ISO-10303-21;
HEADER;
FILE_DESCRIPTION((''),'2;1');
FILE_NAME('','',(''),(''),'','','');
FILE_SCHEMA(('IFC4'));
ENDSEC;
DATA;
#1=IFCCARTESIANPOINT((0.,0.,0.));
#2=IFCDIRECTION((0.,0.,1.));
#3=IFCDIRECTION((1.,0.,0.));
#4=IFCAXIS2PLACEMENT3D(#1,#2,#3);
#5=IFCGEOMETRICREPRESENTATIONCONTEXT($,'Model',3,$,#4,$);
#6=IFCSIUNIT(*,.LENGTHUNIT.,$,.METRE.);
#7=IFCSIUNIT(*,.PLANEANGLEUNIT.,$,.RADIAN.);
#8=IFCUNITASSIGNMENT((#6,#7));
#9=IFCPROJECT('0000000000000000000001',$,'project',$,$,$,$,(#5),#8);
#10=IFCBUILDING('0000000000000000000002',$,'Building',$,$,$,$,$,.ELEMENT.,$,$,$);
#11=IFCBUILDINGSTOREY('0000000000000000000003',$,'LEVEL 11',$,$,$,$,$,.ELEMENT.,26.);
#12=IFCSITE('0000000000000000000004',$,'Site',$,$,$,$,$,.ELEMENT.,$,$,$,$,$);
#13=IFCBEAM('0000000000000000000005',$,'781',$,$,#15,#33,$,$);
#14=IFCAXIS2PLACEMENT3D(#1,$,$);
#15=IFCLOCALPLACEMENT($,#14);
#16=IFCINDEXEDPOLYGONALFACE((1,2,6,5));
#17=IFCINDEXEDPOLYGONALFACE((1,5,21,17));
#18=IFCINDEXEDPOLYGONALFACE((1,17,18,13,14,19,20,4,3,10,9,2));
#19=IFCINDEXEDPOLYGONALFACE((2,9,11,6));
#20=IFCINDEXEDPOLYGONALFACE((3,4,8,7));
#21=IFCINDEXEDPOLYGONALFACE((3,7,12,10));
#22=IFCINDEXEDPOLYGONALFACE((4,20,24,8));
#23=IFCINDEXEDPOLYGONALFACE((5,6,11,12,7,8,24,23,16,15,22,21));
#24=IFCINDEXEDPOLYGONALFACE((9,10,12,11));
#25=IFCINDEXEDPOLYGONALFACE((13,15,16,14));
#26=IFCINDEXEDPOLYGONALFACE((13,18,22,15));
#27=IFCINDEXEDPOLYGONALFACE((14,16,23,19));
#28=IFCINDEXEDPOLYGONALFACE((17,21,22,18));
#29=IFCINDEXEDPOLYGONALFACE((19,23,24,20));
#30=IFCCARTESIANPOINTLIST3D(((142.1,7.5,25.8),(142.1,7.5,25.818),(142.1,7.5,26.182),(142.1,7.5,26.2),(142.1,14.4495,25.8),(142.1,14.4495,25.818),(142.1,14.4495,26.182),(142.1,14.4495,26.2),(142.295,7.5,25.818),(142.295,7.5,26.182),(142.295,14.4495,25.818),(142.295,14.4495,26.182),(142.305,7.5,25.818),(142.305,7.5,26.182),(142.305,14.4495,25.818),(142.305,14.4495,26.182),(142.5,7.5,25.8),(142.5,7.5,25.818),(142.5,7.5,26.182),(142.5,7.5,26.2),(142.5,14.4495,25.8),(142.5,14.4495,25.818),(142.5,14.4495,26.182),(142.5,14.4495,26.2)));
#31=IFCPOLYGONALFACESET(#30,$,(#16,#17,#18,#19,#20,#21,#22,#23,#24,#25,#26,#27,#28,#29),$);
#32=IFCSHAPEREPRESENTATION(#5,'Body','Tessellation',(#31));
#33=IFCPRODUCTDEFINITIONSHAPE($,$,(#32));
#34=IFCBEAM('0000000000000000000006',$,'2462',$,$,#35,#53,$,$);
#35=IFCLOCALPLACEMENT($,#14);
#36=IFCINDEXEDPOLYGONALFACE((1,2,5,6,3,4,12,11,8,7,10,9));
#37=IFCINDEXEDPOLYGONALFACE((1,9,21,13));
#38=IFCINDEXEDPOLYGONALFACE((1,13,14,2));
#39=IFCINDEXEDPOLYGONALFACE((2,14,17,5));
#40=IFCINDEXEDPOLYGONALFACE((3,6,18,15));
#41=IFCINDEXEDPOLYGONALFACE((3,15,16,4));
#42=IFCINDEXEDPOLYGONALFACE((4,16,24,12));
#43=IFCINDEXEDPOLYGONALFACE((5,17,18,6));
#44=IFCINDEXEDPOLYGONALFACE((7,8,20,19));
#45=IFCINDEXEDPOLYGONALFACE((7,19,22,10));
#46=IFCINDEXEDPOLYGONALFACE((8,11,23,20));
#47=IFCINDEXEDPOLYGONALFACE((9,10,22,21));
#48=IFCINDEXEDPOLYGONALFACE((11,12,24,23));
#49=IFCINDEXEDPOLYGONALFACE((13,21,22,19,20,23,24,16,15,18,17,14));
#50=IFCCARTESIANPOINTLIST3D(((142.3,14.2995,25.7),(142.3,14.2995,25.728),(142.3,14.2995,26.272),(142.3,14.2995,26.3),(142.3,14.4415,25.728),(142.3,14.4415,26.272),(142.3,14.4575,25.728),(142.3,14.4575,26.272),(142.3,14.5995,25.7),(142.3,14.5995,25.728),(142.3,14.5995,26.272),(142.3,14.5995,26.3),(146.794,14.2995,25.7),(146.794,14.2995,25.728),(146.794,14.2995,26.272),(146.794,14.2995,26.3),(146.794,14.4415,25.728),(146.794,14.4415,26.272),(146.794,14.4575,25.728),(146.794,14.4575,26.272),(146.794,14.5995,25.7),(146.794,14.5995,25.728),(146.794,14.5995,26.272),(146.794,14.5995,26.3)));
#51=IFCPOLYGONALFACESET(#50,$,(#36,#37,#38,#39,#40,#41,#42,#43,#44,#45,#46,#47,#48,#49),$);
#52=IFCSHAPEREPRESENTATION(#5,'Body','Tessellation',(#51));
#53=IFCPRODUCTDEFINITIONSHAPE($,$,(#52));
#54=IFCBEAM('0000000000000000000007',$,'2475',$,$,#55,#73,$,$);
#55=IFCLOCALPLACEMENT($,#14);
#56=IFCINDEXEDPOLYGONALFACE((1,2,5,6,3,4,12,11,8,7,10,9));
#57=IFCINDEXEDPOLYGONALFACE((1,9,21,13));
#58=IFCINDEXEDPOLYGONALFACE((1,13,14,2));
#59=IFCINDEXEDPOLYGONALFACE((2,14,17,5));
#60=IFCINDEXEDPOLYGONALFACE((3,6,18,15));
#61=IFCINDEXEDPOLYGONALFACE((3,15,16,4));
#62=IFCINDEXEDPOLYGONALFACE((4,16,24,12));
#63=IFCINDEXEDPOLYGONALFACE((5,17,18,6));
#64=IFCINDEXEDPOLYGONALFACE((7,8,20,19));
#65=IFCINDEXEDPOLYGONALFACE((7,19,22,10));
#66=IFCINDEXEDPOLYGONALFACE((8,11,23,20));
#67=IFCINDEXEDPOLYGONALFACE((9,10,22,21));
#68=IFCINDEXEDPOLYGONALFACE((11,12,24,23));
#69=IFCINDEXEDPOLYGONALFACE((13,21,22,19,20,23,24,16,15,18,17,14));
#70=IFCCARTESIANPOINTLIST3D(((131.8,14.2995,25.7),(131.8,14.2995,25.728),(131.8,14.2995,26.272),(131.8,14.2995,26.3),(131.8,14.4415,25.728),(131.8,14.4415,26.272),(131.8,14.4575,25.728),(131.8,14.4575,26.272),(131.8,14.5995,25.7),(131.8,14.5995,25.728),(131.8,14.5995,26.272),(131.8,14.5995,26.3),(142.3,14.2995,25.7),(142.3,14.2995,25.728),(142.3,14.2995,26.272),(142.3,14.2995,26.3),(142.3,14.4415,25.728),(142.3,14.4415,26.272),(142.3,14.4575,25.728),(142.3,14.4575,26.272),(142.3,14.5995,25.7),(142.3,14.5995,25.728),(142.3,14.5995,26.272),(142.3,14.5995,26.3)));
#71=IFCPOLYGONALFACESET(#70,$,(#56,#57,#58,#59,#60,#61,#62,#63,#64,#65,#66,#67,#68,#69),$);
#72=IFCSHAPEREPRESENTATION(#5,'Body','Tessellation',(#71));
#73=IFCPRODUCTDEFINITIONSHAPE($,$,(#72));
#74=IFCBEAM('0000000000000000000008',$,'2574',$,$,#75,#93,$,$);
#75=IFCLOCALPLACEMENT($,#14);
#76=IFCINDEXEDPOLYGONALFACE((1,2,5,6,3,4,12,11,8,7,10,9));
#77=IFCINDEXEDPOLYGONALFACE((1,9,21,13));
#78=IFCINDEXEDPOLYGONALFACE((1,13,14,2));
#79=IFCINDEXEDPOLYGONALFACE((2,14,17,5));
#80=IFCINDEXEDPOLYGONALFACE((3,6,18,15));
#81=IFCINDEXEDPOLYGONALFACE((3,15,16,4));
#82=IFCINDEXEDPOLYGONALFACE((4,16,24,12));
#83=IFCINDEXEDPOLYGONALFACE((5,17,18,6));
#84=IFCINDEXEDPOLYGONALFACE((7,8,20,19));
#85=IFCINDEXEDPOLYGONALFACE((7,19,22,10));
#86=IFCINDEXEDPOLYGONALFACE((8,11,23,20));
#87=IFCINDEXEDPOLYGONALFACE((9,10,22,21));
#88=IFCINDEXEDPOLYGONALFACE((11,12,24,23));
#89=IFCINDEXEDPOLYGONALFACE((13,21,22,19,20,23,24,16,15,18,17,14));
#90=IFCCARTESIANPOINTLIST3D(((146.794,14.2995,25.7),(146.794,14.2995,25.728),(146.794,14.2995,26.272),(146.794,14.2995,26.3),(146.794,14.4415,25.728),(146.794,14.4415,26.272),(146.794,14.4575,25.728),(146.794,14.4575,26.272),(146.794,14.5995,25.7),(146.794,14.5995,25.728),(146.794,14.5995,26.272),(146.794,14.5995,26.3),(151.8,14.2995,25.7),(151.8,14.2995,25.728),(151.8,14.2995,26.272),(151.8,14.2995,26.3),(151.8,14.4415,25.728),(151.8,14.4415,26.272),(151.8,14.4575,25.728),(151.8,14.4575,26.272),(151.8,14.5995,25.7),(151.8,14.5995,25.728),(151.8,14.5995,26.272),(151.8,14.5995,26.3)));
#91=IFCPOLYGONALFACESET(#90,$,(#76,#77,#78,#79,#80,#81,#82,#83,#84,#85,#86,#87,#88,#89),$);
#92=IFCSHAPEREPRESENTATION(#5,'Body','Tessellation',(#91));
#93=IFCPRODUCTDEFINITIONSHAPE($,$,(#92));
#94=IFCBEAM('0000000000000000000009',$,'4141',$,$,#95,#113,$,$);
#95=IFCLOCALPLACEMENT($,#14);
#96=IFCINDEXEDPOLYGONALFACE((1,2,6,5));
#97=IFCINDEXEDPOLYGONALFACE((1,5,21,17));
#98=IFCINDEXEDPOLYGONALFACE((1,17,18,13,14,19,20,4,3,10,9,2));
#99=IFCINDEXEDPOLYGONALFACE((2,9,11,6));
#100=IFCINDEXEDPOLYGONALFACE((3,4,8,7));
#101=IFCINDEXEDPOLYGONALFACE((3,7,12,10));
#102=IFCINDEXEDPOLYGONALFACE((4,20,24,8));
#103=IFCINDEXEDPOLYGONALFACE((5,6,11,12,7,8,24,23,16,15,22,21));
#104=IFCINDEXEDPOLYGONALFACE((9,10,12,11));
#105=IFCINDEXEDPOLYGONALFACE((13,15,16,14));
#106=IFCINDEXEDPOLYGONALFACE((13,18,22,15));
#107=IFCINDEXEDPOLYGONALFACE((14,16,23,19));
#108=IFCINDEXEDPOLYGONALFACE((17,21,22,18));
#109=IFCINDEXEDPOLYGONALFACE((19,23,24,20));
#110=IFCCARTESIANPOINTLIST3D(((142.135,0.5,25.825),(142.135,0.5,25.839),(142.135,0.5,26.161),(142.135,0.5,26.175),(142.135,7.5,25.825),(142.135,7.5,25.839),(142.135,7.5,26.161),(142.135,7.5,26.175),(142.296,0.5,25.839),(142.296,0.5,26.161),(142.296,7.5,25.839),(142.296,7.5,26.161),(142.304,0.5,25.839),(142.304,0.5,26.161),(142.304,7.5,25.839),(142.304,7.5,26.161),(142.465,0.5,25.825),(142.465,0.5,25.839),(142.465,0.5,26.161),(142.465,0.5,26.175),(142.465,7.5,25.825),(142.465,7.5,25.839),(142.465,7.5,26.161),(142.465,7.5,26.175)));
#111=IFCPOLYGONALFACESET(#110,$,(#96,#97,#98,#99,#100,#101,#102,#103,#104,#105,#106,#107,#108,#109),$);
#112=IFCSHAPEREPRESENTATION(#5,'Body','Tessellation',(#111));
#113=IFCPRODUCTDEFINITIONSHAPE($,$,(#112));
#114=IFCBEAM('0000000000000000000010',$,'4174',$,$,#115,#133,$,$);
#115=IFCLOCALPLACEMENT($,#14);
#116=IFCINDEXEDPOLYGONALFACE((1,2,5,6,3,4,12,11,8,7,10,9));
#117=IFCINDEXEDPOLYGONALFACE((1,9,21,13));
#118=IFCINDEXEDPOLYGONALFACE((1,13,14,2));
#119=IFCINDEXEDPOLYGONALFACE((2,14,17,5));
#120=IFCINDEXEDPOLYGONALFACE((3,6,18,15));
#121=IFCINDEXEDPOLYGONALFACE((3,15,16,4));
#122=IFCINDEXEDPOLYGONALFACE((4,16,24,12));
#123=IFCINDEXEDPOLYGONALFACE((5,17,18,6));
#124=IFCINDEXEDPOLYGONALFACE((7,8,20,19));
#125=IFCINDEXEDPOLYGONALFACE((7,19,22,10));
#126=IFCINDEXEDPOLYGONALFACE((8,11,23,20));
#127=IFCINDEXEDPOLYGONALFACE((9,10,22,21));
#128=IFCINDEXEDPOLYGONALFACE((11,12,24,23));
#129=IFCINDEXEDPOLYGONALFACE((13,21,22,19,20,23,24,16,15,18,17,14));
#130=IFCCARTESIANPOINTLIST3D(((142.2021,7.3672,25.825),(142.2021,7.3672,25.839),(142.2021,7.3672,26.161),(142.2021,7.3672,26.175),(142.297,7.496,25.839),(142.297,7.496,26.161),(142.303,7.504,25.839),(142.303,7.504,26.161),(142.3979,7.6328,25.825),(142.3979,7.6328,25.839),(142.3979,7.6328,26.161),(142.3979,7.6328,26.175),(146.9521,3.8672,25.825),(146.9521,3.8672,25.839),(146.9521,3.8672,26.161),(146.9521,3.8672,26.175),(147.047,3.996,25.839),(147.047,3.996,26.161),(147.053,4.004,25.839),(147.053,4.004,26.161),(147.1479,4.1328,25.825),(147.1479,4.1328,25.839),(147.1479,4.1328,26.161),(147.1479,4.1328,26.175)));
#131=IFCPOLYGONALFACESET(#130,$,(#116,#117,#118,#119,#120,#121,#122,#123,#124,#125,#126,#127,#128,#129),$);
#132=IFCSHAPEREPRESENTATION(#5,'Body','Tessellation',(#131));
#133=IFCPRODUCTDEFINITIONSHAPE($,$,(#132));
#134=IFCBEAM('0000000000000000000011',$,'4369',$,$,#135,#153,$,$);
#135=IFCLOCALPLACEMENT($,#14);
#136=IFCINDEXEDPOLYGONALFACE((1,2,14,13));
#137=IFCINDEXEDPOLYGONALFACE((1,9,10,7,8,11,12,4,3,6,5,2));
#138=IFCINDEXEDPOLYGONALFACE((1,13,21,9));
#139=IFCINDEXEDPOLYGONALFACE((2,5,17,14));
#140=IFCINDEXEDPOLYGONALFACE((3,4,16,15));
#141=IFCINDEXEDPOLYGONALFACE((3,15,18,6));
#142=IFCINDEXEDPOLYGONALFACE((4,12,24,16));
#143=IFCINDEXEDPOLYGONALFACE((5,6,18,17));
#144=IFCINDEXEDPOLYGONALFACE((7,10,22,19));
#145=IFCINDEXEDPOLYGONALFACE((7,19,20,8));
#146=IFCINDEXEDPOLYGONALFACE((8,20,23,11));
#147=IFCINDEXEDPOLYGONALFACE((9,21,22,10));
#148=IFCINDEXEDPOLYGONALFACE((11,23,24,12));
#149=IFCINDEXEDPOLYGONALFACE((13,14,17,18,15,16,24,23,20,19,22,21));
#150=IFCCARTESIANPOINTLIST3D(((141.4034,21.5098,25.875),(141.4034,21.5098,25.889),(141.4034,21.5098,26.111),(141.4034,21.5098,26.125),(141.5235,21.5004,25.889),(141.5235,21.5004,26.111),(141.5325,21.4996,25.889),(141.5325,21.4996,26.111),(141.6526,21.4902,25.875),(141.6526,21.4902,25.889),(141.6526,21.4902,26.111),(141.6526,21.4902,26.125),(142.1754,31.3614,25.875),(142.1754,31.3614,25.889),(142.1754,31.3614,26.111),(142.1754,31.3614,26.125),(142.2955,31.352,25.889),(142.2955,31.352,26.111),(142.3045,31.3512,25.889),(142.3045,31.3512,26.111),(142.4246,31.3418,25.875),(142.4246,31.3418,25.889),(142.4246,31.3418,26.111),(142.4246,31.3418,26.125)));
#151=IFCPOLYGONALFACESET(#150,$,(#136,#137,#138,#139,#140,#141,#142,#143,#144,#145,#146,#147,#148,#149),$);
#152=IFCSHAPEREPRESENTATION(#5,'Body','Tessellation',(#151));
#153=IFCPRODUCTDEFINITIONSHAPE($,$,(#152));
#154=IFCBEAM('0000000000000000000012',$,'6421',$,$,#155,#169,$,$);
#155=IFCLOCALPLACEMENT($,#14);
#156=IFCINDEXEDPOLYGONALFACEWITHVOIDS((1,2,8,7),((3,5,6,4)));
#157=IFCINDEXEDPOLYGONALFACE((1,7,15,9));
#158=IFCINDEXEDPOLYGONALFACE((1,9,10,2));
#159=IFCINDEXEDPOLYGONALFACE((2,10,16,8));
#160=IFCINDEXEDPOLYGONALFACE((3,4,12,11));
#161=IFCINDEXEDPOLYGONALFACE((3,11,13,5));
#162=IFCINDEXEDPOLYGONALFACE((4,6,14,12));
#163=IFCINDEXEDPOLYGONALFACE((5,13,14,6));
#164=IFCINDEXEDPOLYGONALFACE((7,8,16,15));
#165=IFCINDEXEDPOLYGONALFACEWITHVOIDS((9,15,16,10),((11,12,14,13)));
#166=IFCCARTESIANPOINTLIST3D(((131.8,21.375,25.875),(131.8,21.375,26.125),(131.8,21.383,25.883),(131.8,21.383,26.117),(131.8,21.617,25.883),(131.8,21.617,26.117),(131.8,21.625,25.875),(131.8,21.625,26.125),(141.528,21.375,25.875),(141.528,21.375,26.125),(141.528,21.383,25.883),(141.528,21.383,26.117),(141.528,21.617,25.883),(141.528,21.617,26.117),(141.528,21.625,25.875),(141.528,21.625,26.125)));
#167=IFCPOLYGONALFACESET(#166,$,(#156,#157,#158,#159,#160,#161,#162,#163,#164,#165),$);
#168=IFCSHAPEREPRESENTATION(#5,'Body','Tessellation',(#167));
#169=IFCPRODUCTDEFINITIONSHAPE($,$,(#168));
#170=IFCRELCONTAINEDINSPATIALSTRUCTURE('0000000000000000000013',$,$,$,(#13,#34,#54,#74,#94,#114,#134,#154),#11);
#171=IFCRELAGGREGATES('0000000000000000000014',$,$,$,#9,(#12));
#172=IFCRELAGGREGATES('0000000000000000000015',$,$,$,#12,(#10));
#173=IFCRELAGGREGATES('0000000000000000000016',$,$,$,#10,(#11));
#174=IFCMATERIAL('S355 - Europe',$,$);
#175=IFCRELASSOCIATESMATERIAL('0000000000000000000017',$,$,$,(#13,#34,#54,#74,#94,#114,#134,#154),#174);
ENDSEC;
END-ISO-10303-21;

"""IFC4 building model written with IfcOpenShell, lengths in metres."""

from ifc_helpers import new_model, si_unit, frame, origin_with_axes, origin_2d_with_axis, place, context, project, spatial, hollow_rectangle, i_section, extrude, material, material_profile, profile_set, profile_usage, element, save


model = new_model("IFC4")

# Units and contexts
model_context = context("Model", 3, world=origin_with_axes())
ifc_project = project(units=[si_unit("LENGTHUNIT", "METRE"), si_unit("PLANEANGLEUNIT", "RADIAN")], contexts=[model_context])

# Site, building, storey
site = spatial("IfcSite", under=ifc_project, Name="Site", CompositionType="ELEMENT")
building = spatial("IfcBuilding", under=site, Name="Building", CompositionType="ELEMENT")
storey = spatial("IfcBuildingStorey", under=building, Name="LEVEL 11", CompositionType="ELEMENT", Elevation=26.0)

# Shared definitions
ifc_material = material(Name="S355 - Europe")

# Beams
ifc_material_profile_1 = material_profile(ifc_material, i_section(OverallWidth=0.4, OverallDepth=0.4, WebThickness=0.01, FlangeThickness=0.018, at=origin_2d_with_axis()))
ifc_profile_set_1 = profile_set([ifc_material_profile_1])
ifc_profile_usage_1 = profile_usage(ifc_profile_set_1, cardinal=10)
beam_1_placement = place(None, frame((142.3, 14.4495, 26.0), z_axis=(0.0, -1.0, 0.0), x_axis=(1.0, 0.0, 0.0)))
element("IfcBeam", 1, at=beam_1_placement, inside=storey, material=ifc_profile_usage_1, Name="781", context=model_context, shape_type="SweptSolid", body=[
    extrude(i_section(OverallWidth=0.4, OverallDepth=0.4, WebThickness=0.01, FlangeThickness=0.018, at=origin_2d_with_axis()), origin_with_axes(), (0.0, 0.0, 1.0), 6.9495),
])
ifc_material_profile_2 = material_profile(ifc_material, i_section(OverallWidth=0.3, OverallDepth=0.6, WebThickness=0.016, FlangeThickness=0.028, at=origin_2d_with_axis()))
ifc_profile_set_2 = profile_set([ifc_material_profile_2])
ifc_profile_usage_2 = profile_usage(ifc_profile_set_2, cardinal=10)
beam_2_placement = place(None, frame((142.3, 14.4495, 26.0), z_axis=(1.0, 0.0, 0.0), x_axis=(0.0, 1.0, 0.0)))
element("IfcBeam", 2, at=beam_2_placement, inside=storey, material=ifc_profile_usage_2, Name="2462", context=model_context, shape_type="SweptSolid", body=[
    extrude(i_section(OverallWidth=0.3, OverallDepth=0.6, WebThickness=0.016, FlangeThickness=0.028, at=origin_2d_with_axis()), origin_with_axes(), (0.0, 0.0, 1.0), 4.494),
])
ifc_material_profile_3 = material_profile(ifc_material, i_section(OverallWidth=0.3, OverallDepth=0.6, WebThickness=0.016, FlangeThickness=0.028, at=origin_2d_with_axis()))
ifc_profile_set_3 = profile_set([ifc_material_profile_3])
ifc_profile_usage_3 = profile_usage(ifc_profile_set_3, cardinal=10)
beam_3_placement = place(None, frame((131.8, 14.4495, 26.0), z_axis=(1.0, 0.0, 0.0), x_axis=(0.0, 1.0, 0.0)))
element("IfcBeam", 3, at=beam_3_placement, inside=storey, material=ifc_profile_usage_3, Name="2475", context=model_context, shape_type="SweptSolid", body=[
    extrude(i_section(OverallWidth=0.3, OverallDepth=0.6, WebThickness=0.016, FlangeThickness=0.028, at=origin_2d_with_axis()), origin_with_axes(), (0.0, 0.0, 1.0), 10.5),
])
ifc_material_profile_4 = material_profile(ifc_material, i_section(OverallWidth=0.3, OverallDepth=0.6, WebThickness=0.016, FlangeThickness=0.028, at=origin_2d_with_axis()))
ifc_profile_set_4 = profile_set([ifc_material_profile_4])
ifc_profile_usage_4 = profile_usage(ifc_profile_set_4, cardinal=10)
beam_4_placement = place(None, frame((146.794, 14.4495, 26.0), z_axis=(1.0, 0.0, 0.0), x_axis=(0.0, 1.0, 0.0)))
element("IfcBeam", 4, at=beam_4_placement, inside=storey, material=ifc_profile_usage_4, Name="2574", context=model_context, shape_type="SweptSolid", body=[
    extrude(i_section(OverallWidth=0.3, OverallDepth=0.6, WebThickness=0.016, FlangeThickness=0.028, at=origin_2d_with_axis()), origin_with_axes(), (0.0, 0.0, 1.0), 5.006),
])
ifc_material_profile_5 = material_profile(ifc_material, i_section(OverallWidth=0.33, OverallDepth=0.35, WebThickness=0.008, FlangeThickness=0.014, at=origin_2d_with_axis()))
ifc_profile_set_5 = profile_set([ifc_material_profile_5])
ifc_profile_usage_5 = profile_usage(ifc_profile_set_5, cardinal=10)
beam_5_placement = place(None, frame((142.3, 7.5, 26.0), z_axis=(0.0, -1.0, 0.0), x_axis=(1.0, 0.0, 0.0)))
element("IfcBeam", 5, at=beam_5_placement, inside=storey, material=ifc_profile_usage_5, Name="4141", context=model_context, shape_type="SweptSolid", body=[
    extrude(i_section(OverallWidth=0.33, OverallDepth=0.35, WebThickness=0.008, FlangeThickness=0.014, at=origin_2d_with_axis()), origin_with_axes(), (0.0, 0.0, 1.0), 7.0),
])
ifc_material_profile_6 = material_profile(ifc_material, i_section(OverallWidth=0.33, OverallDepth=0.35, WebThickness=0.01, FlangeThickness=0.014, at=origin_2d_with_axis()))
ifc_profile_set_6 = profile_set([ifc_material_profile_6])
ifc_profile_usage_6 = profile_usage(ifc_profile_set_6, cardinal=10)
beam_6_placement = place(None, frame((142.3, 7.5, 26.0), z_axis=(0.805056, -0.593199, 0.0), x_axis=(0.593199, 0.805056, 0.0)))
element("IfcBeam", 6, at=beam_6_placement, inside=storey, material=ifc_profile_usage_6, Name="4174", context=model_context, shape_type="SweptSolid", body=[
    extrude(i_section(OverallWidth=0.33, OverallDepth=0.35, WebThickness=0.01, FlangeThickness=0.014, at=origin_2d_with_axis()), origin_with_axes(), (0.0, 0.0, 1.0), 5.9002),
])
ifc_material_profile_7 = material_profile(ifc_material, i_section(OverallWidth=0.25, OverallDepth=0.25, WebThickness=0.009, FlangeThickness=0.014, at=origin_2d_with_axis()))
ifc_profile_set_7 = profile_set([ifc_material_profile_7])
ifc_profile_usage_7 = profile_usage(ifc_profile_set_7, cardinal=10)
beam_7_placement = place(None, frame((141.528, 21.5, 26.0), z_axis=(0.078123, 0.996944, 0.0), x_axis=(-0.996944, 0.078123, 0.0)))
element("IfcBeam", 7, at=beam_7_placement, inside=storey, material=ifc_profile_usage_7, Name="4369", context=model_context, shape_type="SweptSolid", body=[
    extrude(i_section(OverallWidth=0.25, OverallDepth=0.25, WebThickness=0.009, FlangeThickness=0.014, at=origin_2d_with_axis()), origin_with_axes(), (0.0, 0.0, 1.0), 9.8818),
])
ifc_material_profile_8 = material_profile(ifc_material, hollow_rectangle(XDim=0.25, YDim=0.25, WallThickness=0.008, at=origin_2d_with_axis()))
ifc_profile_set_8 = profile_set([ifc_material_profile_8])
ifc_profile_usage_8 = profile_usage(ifc_profile_set_8, cardinal=10)
beam_8_placement = place(None, frame((131.8, 21.5, 26.0), z_axis=(1.0, 0.0, 0.0), x_axis=(0.0, 1.0, 0.0)))
element("IfcBeam", 8, at=beam_8_placement, inside=storey, material=ifc_profile_usage_8, Name="6421", context=model_context, shape_type="SweptSolid", body=[
    extrude(hollow_rectangle(XDim=0.25, YDim=0.25, WallThickness=0.008, at=origin_2d_with_axis()), origin_with_axes(), (0.0, 0.0, 1.0), 9.728),
])

save(model, "model.ifc")
